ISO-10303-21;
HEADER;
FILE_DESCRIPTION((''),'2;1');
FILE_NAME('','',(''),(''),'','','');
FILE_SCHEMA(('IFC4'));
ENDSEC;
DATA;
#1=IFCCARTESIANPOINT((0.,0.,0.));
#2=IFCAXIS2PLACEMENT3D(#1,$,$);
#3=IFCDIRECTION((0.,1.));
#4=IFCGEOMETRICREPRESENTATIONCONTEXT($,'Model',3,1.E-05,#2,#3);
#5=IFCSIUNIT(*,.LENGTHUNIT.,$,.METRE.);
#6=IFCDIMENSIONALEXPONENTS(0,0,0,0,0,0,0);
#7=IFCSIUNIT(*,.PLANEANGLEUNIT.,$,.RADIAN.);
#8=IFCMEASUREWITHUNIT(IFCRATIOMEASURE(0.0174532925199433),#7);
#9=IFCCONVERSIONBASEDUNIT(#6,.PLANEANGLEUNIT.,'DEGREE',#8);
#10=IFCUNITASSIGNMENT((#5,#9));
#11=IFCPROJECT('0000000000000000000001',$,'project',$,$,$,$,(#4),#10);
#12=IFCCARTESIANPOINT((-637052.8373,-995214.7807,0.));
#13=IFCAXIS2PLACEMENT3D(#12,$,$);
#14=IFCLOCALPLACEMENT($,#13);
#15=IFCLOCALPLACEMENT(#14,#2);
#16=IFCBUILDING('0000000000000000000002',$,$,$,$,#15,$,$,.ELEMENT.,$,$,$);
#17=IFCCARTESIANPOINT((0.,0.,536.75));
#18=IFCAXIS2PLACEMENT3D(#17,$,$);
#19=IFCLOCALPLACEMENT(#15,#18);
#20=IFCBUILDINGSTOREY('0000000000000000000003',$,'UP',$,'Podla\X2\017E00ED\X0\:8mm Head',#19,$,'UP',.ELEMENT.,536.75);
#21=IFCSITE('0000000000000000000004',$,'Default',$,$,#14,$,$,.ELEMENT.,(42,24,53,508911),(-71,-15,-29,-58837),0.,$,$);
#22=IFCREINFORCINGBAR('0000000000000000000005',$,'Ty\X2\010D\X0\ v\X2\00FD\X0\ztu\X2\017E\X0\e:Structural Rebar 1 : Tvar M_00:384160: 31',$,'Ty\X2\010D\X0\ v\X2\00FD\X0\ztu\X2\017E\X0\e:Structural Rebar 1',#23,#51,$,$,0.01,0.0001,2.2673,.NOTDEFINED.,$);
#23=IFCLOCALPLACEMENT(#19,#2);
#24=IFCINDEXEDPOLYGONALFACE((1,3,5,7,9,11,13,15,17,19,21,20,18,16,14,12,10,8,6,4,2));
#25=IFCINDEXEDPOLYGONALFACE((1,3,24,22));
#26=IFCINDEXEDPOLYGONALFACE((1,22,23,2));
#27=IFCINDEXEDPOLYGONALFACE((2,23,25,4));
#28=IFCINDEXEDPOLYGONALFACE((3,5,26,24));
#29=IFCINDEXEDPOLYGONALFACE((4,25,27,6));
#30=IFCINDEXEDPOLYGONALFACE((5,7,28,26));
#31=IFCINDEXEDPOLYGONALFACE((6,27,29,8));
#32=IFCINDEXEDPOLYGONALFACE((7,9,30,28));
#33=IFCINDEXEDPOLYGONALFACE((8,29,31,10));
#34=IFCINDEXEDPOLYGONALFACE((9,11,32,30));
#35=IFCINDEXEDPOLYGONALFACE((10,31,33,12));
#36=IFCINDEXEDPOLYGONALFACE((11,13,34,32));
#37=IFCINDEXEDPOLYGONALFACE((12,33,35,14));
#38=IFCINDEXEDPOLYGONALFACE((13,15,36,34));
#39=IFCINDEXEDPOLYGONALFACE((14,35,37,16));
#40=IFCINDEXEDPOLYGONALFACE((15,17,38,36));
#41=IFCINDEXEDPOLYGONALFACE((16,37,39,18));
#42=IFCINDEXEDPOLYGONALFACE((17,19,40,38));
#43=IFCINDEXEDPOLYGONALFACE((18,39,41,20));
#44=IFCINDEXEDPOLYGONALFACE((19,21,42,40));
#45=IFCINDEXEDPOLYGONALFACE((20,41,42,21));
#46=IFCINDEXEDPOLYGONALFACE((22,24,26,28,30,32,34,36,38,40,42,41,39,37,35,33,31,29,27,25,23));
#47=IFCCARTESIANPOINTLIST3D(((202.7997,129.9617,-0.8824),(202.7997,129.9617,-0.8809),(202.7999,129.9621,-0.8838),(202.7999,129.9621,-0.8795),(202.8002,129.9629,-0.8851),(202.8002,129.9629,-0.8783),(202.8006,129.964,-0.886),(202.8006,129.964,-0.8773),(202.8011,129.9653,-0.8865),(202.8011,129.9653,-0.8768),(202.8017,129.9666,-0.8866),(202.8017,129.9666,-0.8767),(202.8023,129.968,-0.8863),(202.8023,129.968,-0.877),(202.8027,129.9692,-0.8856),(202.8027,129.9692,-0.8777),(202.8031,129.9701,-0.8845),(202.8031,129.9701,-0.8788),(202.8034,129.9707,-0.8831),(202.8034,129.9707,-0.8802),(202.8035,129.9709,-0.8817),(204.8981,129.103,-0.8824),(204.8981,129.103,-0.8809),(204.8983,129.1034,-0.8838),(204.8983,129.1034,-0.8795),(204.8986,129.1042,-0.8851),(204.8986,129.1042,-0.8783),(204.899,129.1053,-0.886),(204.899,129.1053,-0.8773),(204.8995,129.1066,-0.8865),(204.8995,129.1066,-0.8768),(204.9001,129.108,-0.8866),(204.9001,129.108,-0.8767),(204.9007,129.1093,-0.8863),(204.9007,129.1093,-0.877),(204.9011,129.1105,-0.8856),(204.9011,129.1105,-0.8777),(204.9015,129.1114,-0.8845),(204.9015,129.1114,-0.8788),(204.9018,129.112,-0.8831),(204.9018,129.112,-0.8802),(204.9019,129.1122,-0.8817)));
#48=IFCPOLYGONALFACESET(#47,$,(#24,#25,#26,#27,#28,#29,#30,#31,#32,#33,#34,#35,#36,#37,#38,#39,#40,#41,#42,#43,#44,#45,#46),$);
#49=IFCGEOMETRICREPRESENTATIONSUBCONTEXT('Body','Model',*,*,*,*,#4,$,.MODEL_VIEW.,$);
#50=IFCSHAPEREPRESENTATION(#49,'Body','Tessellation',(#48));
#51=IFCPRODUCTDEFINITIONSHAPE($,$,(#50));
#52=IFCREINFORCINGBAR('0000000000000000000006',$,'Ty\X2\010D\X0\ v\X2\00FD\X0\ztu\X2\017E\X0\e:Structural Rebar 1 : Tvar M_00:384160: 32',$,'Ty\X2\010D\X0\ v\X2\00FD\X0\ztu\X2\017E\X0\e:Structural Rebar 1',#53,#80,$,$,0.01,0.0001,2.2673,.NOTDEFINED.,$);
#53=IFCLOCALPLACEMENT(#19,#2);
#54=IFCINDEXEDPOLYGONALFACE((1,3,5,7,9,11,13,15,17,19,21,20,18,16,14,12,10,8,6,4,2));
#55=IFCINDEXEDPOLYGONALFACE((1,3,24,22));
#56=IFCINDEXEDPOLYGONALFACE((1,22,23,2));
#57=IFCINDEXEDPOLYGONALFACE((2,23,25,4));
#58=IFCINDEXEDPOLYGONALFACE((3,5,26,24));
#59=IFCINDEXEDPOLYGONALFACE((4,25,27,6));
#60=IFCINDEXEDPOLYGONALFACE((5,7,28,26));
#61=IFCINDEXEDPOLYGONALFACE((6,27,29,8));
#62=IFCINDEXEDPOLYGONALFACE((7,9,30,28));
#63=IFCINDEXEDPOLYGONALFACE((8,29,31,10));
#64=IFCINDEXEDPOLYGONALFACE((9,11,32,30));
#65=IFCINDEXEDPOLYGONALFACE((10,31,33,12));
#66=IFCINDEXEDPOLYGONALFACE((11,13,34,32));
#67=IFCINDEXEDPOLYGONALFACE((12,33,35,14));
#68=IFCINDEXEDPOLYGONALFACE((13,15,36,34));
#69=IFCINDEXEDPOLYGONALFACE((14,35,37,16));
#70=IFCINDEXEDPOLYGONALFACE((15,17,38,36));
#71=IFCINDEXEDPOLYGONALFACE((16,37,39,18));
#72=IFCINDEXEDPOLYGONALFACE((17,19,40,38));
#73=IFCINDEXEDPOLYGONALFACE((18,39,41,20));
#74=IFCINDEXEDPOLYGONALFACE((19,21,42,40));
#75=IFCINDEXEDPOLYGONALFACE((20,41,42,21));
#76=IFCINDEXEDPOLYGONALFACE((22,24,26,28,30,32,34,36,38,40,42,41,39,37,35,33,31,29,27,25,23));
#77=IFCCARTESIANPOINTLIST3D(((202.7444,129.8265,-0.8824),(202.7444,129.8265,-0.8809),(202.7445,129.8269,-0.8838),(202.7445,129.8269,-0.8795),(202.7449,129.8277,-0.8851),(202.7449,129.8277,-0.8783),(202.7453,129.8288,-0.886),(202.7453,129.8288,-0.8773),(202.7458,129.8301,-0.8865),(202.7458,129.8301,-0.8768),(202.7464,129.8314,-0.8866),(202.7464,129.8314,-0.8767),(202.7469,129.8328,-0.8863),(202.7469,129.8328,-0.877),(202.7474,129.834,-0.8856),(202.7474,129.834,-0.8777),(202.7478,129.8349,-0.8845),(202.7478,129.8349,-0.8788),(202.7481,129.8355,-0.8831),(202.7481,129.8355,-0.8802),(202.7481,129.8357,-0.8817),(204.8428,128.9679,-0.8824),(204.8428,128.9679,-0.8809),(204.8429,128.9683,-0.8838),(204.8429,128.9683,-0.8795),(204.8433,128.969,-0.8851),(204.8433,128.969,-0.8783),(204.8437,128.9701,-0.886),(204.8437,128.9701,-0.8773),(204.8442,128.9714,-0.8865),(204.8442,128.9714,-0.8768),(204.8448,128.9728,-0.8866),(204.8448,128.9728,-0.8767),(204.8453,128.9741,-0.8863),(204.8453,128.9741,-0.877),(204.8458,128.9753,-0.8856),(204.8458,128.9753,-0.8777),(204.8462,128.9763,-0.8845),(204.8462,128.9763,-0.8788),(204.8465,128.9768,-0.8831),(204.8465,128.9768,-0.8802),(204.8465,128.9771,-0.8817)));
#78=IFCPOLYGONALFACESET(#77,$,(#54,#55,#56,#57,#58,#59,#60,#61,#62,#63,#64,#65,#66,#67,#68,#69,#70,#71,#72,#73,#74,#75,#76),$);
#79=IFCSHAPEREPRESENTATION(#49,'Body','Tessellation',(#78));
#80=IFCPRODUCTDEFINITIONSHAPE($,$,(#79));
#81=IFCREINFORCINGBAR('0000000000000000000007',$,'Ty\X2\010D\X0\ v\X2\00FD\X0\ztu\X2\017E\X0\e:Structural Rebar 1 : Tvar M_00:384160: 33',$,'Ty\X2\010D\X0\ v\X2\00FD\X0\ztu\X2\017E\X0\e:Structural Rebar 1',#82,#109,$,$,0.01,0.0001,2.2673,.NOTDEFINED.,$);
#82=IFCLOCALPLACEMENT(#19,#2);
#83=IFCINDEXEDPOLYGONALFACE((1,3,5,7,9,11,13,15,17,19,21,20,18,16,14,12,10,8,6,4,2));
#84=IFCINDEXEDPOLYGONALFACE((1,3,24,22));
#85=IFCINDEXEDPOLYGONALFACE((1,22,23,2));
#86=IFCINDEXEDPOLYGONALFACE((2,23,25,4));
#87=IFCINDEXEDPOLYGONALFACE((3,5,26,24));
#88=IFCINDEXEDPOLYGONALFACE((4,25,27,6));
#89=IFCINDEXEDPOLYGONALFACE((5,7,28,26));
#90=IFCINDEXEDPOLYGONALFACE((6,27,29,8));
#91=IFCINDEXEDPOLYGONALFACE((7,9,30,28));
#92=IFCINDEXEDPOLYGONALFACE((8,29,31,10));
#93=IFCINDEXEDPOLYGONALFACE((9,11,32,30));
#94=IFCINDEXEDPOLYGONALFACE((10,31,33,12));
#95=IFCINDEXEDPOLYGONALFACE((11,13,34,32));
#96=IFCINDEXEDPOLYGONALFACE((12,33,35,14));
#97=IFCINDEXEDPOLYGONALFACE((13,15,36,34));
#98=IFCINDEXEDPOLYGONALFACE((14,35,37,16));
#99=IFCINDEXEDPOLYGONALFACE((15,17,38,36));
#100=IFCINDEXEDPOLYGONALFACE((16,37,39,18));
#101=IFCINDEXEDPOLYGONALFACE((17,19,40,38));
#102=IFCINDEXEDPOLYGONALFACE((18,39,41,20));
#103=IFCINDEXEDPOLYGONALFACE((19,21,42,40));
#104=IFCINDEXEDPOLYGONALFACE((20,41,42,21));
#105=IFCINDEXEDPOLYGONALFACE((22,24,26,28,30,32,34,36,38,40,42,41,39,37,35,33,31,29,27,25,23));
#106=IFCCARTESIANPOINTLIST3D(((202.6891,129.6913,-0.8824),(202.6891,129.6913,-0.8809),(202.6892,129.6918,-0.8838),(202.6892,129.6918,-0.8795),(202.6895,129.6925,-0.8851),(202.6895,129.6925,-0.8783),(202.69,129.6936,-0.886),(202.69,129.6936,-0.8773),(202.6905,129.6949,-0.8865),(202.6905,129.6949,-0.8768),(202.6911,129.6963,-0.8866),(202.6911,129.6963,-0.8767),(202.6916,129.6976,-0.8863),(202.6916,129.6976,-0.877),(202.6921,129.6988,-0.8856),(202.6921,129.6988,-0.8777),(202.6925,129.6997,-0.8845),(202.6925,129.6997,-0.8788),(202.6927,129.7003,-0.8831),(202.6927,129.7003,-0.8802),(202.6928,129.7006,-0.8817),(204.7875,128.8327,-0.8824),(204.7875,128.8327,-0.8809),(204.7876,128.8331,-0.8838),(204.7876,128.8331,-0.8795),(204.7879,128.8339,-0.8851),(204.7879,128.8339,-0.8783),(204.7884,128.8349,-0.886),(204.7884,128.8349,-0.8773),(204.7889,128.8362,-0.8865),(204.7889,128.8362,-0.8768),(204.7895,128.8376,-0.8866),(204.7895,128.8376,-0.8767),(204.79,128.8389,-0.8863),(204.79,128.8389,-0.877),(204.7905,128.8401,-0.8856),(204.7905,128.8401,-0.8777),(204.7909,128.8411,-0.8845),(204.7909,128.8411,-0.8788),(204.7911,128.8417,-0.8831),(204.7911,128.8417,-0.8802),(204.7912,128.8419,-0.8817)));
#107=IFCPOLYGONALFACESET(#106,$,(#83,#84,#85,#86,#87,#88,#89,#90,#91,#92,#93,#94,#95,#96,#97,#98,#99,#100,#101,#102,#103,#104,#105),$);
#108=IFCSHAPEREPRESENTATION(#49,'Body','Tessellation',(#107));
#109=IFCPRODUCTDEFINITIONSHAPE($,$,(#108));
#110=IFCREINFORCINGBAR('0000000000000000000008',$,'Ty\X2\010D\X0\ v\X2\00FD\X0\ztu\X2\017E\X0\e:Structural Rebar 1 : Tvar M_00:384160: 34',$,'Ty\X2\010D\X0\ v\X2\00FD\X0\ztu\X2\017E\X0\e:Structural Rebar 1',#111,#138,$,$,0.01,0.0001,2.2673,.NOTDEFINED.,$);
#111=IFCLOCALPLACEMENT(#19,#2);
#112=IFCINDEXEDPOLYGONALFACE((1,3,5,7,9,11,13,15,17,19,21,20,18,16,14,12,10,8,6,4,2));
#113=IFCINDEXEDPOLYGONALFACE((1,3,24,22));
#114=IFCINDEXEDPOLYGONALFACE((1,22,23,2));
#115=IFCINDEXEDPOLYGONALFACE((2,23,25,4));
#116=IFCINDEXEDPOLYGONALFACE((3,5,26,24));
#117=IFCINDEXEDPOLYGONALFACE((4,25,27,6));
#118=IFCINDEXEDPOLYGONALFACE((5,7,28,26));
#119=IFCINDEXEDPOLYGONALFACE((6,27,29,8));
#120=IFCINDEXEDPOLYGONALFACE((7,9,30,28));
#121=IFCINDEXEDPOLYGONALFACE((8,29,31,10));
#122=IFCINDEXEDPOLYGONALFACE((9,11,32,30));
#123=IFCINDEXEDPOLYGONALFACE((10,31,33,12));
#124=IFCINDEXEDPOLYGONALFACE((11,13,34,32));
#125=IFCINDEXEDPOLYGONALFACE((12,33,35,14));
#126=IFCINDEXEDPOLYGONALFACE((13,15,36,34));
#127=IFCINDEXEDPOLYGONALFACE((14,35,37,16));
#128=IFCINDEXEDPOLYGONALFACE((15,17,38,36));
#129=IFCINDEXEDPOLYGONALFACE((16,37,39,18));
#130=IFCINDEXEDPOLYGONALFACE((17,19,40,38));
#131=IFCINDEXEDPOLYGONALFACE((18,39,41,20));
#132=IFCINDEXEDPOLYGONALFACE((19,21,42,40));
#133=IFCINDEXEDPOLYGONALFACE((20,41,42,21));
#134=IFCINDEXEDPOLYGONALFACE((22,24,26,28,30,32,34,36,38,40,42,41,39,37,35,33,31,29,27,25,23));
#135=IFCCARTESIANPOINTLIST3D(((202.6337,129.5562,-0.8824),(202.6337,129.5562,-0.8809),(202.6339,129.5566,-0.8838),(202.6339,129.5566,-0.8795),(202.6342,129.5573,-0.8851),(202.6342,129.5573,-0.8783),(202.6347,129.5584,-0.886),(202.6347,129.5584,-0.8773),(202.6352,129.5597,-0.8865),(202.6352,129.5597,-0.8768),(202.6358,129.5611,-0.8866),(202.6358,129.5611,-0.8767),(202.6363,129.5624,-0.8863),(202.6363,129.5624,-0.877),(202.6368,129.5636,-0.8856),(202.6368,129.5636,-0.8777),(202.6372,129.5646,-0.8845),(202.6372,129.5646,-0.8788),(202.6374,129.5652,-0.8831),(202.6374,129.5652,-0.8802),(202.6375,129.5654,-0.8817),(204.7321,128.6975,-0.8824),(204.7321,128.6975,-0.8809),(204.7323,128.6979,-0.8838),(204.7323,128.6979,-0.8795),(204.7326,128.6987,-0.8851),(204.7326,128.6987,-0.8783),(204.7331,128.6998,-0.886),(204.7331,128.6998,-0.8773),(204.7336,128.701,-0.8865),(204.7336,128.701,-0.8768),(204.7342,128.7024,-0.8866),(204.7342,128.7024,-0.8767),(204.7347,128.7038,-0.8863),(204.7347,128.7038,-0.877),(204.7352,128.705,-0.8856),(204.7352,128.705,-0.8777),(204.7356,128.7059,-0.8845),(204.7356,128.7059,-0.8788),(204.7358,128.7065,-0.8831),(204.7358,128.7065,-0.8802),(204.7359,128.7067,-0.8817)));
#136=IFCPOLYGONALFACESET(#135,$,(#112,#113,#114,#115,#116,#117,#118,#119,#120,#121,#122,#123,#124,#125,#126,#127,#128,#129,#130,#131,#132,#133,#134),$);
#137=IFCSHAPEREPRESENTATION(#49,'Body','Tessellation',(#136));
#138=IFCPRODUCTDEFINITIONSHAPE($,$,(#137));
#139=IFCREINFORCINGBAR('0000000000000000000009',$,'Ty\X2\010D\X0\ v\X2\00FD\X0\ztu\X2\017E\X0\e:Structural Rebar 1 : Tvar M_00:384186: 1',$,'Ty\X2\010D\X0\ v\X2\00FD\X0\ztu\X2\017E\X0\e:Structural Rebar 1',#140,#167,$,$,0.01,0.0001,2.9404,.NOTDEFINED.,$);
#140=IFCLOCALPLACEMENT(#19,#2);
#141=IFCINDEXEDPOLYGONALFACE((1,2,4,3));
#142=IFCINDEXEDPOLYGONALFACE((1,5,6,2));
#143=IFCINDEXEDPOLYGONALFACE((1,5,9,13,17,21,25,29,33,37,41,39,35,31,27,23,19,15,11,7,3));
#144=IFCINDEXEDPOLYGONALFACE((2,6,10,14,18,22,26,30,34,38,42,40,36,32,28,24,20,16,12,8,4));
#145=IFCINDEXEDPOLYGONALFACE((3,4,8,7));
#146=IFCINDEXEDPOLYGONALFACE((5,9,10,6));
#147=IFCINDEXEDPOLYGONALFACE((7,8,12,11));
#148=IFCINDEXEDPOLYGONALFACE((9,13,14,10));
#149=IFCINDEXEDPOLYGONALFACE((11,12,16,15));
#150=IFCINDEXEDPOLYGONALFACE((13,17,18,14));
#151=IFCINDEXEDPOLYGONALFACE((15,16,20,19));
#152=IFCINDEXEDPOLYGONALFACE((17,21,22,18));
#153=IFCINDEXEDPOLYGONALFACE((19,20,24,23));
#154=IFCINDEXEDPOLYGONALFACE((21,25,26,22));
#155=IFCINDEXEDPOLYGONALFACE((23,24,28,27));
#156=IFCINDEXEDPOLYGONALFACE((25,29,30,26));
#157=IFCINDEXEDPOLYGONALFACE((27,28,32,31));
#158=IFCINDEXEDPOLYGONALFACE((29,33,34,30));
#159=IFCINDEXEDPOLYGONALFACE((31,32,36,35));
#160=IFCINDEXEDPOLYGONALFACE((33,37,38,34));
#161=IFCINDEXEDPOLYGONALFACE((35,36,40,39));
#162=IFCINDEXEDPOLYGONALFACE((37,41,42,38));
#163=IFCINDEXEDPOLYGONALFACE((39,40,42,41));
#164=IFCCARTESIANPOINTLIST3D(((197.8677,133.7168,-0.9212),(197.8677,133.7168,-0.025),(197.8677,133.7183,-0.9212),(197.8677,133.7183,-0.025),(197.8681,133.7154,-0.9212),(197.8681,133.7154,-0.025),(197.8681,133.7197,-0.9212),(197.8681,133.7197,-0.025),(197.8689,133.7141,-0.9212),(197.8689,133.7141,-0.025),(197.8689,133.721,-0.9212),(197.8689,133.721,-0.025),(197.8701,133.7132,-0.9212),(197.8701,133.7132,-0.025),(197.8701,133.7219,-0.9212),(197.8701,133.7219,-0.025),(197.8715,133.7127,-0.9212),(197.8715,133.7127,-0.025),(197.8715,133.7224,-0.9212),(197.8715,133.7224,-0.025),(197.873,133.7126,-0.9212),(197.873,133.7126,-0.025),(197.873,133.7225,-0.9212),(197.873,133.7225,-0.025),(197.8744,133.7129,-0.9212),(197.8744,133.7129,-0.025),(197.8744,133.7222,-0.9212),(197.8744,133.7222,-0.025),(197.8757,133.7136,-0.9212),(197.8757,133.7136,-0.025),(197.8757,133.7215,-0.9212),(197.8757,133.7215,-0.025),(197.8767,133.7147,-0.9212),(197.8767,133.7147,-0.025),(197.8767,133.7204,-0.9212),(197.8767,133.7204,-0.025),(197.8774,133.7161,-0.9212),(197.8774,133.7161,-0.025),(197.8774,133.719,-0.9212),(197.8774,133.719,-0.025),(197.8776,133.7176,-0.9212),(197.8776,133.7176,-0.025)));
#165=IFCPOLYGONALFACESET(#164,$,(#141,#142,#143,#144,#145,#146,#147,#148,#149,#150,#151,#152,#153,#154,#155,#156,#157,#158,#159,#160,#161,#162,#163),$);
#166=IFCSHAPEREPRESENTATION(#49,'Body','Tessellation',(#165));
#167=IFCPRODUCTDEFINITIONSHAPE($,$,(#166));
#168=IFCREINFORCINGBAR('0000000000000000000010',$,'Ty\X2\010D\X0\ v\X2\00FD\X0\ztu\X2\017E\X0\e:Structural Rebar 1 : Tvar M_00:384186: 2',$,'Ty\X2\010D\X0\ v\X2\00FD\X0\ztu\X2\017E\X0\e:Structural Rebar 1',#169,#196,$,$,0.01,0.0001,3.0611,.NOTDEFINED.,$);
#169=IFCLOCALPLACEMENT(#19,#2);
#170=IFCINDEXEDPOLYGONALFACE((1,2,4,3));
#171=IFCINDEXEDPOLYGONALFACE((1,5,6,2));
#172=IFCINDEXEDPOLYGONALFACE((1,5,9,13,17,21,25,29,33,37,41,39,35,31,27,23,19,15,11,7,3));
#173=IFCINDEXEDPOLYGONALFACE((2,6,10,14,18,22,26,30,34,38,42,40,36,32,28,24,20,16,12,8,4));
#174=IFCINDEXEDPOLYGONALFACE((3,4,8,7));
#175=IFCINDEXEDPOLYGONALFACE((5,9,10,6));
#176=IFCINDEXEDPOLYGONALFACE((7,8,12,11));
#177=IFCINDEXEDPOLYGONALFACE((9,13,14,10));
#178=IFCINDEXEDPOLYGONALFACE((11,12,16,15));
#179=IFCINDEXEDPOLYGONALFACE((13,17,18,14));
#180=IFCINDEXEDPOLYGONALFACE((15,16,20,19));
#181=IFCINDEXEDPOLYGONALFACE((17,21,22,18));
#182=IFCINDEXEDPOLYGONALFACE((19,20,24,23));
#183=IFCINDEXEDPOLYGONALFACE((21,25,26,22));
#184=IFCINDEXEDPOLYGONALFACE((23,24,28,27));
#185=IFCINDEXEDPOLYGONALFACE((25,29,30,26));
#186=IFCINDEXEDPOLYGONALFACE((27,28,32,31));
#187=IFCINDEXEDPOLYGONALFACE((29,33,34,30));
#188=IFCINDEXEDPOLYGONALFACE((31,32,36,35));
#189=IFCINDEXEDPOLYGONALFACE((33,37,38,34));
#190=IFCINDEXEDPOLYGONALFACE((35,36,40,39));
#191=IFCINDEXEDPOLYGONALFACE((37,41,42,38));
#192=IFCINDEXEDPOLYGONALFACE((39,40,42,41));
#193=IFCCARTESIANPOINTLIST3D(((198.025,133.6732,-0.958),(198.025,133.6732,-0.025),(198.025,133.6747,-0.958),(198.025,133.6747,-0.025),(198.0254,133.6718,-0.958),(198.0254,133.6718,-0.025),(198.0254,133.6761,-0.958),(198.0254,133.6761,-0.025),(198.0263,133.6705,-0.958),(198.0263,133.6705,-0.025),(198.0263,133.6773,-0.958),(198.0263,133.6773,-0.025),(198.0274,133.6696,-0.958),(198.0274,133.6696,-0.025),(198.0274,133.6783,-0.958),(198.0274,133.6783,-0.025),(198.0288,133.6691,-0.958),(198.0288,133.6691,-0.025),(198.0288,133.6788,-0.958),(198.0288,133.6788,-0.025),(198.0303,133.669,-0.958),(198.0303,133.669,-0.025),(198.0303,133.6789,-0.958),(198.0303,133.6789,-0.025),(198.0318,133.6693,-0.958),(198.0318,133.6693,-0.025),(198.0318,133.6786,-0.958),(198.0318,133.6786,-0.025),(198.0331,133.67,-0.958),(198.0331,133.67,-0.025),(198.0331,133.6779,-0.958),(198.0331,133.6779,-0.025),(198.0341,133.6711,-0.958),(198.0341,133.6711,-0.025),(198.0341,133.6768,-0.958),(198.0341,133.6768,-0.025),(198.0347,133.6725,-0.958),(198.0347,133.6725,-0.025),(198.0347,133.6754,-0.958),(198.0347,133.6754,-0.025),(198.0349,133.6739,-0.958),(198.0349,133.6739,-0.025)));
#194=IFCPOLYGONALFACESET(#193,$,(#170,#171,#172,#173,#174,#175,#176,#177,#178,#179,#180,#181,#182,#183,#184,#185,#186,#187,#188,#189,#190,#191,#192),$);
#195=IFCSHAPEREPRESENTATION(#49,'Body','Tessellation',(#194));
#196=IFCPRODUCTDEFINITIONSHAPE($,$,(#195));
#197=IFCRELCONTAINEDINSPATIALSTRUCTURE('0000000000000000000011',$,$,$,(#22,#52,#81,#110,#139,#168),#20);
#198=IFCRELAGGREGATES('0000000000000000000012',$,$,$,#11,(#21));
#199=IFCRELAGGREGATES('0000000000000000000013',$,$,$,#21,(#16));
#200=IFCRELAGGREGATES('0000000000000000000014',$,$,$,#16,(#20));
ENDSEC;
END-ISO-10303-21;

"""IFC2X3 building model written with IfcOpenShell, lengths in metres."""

from ifc_helpers import new_model, entity, si_unit, converted_unit, direction, frame, origin, place, context, subcontext, project, spatial, element, save


model = new_model("IFC2X3")

# Units and contexts
model_context = context("Model", 3, precision=1e-05, world=origin(), true_north=direction((0.0, 1.0)))
body_context = subcontext(model_context, "Body", "Model", "MODEL_VIEW")
ifc_project = project(units=[si_unit("LENGTHUNIT", "METRE"), converted_unit("PLANEANGLEUNIT", "DEGREE", entity("IfcRatioMeasure", 0.0174532925199433), si_unit("PLANEANGLEUNIT", "RADIAN"), dimensions=[0, 0, 0, 0, 0, 0, 0])], contexts=[model_context])

# Site, building, storey
site_placement = place(None, frame((-637052.8373, -995214.7807, 0.0)))
site = spatial("IfcSite", under=ifc_project, at=site_placement, Name="Default", CompositionType="ELEMENT", RefLatitude=(42, 24, 53, 508911), RefLongitude=(-71, -15, -29, -58837), RefElevation=0.0)
building_placement = place(site_placement, origin())
building = spatial("IfcBuilding", under=site, at=building_placement, CompositionType="ELEMENT")
storey_placement = place(building_placement, frame((0.0, 0.0, 536.75)))
storey = spatial("IfcBuildingStorey", under=building, at=storey_placement, Name="UP", ObjectType="Podlaží:8mm Head", LongName="UP", CompositionType="ELEMENT", Elevation=536.75)

# Reinforcing bars
reinforcing_bar_1_placement = place(storey_placement, origin())
element("IfcReinforcingBar", 1, at=reinforcing_bar_1_placement, inside=storey, Name="Tyč výztuže:Structural Rebar 1 : Tvar M_00:384160: 31", ObjectType="Tyč výztuže:Structural Rebar 1", BarLength=2.2673, BarRole="NOTDEFINED", CrossSectionArea=0.0001, NominalDiameter=0.01, context=body_context, shape_type="AdvancedSweptSolid", body=[
    entity("IfcSweptDiskSolid", entity("IfcCompositeCurve", [entity("IfcCompositeCurveSegment", "CONTINUOUS", True, entity("IfcPolyline", [entity("IfcCartesianPoint", [-204.9, -129.1076, 0.8817]), entity("IfcCartesianPoint", [-202.8016, -129.9663, 0.8817])]))], False), 0.005, None, 0.0, 1.0),
])
reinforcing_bar_2_placement = place(storey_placement, origin())
element("IfcReinforcingBar", 2, at=reinforcing_bar_2_placement, inside=storey, Name="Tyč výztuže:Structural Rebar 1 : Tvar M_00:384160: 32", ObjectType="Tyč výztuže:Structural Rebar 1", BarLength=2.2673, BarRole="NOTDEFINED", CrossSectionArea=0.0001, NominalDiameter=0.01, context=body_context, shape_type="AdvancedSweptSolid", body=[
    entity("IfcSweptDiskSolid", entity("IfcCompositeCurve", [entity("IfcCompositeCurveSegment", "CONTINUOUS", True, entity("IfcPolyline", [entity("IfcCartesianPoint", [-204.8446, -128.9724, 0.8817]), entity("IfcCartesianPoint", [-202.7462, -129.8311, 0.8817])]))], False), 0.005, None, 0.0, 1.0),
])
reinforcing_bar_3_placement = place(storey_placement, origin())
element("IfcReinforcingBar", 3, at=reinforcing_bar_3_placement, inside=storey, Name="Tyč výztuže:Structural Rebar 1 : Tvar M_00:384160: 33", ObjectType="Tyč výztuže:Structural Rebar 1", BarLength=2.2673, BarRole="NOTDEFINED", CrossSectionArea=0.0001, NominalDiameter=0.01, context=body_context, shape_type="AdvancedSweptSolid", body=[
    entity("IfcSweptDiskSolid", entity("IfcCompositeCurve", [entity("IfcCompositeCurveSegment", "CONTINUOUS", True, entity("IfcPolyline", [entity("IfcCartesianPoint", [-204.7893, -128.8372, 0.8817]), entity("IfcCartesianPoint", [-202.6909, -129.6959, 0.8817])]))], False), 0.005, None, 0.0, 1.0),
])
reinforcing_bar_4_placement = place(storey_placement, origin())
element("IfcReinforcingBar", 4, at=reinforcing_bar_4_placement, inside=storey, Name="Tyč výztuže:Structural Rebar 1 : Tvar M_00:384160: 34", ObjectType="Tyč výztuže:Structural Rebar 1", BarLength=2.2673, BarRole="NOTDEFINED", CrossSectionArea=0.0001, NominalDiameter=0.01, context=body_context, shape_type="AdvancedSweptSolid", body=[
    entity("IfcSweptDiskSolid", entity("IfcCompositeCurve", [entity("IfcCompositeCurveSegment", "CONTINUOUS", True, entity("IfcPolyline", [entity("IfcCartesianPoint", [-204.734, -128.7021, 0.8817]), entity("IfcCartesianPoint", [-202.6356, -129.5607, 0.8817])]))], False), 0.005, None, 0.0, 1.0),
])
reinforcing_bar_5_placement = place(storey_placement, origin())
element("IfcReinforcingBar", 5, at=reinforcing_bar_5_placement, inside=storey, Name="Tyč výztuže:Structural Rebar 1 : Tvar M_00:384186: 1", ObjectType="Tyč výztuže:Structural Rebar 1", BarLength=2.9404, BarRole="NOTDEFINED", CrossSectionArea=0.0001, NominalDiameter=0.01, context=body_context, shape_type="AdvancedSweptSolid", body=[
    entity("IfcSweptDiskSolid", entity("IfcCompositeCurve", [entity("IfcCompositeCurveSegment", "CONTINUOUS", True, entity("IfcPolyline", [entity("IfcCartesianPoint", [-197.8726, -133.7176, 0.025]), entity("IfcCartesianPoint", [-197.8726, -133.7176, 0.9212])]))], False), 0.005, None, 0.0, 1.0),
])
reinforcing_bar_6_placement = place(storey_placement, origin())
element("IfcReinforcingBar", 6, at=reinforcing_bar_6_placement, inside=storey, Name="Tyč výztuže:Structural Rebar 1 : Tvar M_00:384186: 2", ObjectType="Tyč výztuže:Structural Rebar 1", BarLength=3.0611, BarRole="NOTDEFINED", CrossSectionArea=0.0001, NominalDiameter=0.01, context=body_context, shape_type="AdvancedSweptSolid", body=[
    entity("IfcSweptDiskSolid", entity("IfcCompositeCurve", [entity("IfcCompositeCurveSegment", "CONTINUOUS", True, entity("IfcPolyline", [entity("IfcCartesianPoint", [-198.0299, -133.6739, 0.025]), entity("IfcCartesianPoint", [-198.0299, -133.6739, 0.958])]))], False), 0.005, None, 0.0, 1.0),
])

save(model, "model.ifc")
